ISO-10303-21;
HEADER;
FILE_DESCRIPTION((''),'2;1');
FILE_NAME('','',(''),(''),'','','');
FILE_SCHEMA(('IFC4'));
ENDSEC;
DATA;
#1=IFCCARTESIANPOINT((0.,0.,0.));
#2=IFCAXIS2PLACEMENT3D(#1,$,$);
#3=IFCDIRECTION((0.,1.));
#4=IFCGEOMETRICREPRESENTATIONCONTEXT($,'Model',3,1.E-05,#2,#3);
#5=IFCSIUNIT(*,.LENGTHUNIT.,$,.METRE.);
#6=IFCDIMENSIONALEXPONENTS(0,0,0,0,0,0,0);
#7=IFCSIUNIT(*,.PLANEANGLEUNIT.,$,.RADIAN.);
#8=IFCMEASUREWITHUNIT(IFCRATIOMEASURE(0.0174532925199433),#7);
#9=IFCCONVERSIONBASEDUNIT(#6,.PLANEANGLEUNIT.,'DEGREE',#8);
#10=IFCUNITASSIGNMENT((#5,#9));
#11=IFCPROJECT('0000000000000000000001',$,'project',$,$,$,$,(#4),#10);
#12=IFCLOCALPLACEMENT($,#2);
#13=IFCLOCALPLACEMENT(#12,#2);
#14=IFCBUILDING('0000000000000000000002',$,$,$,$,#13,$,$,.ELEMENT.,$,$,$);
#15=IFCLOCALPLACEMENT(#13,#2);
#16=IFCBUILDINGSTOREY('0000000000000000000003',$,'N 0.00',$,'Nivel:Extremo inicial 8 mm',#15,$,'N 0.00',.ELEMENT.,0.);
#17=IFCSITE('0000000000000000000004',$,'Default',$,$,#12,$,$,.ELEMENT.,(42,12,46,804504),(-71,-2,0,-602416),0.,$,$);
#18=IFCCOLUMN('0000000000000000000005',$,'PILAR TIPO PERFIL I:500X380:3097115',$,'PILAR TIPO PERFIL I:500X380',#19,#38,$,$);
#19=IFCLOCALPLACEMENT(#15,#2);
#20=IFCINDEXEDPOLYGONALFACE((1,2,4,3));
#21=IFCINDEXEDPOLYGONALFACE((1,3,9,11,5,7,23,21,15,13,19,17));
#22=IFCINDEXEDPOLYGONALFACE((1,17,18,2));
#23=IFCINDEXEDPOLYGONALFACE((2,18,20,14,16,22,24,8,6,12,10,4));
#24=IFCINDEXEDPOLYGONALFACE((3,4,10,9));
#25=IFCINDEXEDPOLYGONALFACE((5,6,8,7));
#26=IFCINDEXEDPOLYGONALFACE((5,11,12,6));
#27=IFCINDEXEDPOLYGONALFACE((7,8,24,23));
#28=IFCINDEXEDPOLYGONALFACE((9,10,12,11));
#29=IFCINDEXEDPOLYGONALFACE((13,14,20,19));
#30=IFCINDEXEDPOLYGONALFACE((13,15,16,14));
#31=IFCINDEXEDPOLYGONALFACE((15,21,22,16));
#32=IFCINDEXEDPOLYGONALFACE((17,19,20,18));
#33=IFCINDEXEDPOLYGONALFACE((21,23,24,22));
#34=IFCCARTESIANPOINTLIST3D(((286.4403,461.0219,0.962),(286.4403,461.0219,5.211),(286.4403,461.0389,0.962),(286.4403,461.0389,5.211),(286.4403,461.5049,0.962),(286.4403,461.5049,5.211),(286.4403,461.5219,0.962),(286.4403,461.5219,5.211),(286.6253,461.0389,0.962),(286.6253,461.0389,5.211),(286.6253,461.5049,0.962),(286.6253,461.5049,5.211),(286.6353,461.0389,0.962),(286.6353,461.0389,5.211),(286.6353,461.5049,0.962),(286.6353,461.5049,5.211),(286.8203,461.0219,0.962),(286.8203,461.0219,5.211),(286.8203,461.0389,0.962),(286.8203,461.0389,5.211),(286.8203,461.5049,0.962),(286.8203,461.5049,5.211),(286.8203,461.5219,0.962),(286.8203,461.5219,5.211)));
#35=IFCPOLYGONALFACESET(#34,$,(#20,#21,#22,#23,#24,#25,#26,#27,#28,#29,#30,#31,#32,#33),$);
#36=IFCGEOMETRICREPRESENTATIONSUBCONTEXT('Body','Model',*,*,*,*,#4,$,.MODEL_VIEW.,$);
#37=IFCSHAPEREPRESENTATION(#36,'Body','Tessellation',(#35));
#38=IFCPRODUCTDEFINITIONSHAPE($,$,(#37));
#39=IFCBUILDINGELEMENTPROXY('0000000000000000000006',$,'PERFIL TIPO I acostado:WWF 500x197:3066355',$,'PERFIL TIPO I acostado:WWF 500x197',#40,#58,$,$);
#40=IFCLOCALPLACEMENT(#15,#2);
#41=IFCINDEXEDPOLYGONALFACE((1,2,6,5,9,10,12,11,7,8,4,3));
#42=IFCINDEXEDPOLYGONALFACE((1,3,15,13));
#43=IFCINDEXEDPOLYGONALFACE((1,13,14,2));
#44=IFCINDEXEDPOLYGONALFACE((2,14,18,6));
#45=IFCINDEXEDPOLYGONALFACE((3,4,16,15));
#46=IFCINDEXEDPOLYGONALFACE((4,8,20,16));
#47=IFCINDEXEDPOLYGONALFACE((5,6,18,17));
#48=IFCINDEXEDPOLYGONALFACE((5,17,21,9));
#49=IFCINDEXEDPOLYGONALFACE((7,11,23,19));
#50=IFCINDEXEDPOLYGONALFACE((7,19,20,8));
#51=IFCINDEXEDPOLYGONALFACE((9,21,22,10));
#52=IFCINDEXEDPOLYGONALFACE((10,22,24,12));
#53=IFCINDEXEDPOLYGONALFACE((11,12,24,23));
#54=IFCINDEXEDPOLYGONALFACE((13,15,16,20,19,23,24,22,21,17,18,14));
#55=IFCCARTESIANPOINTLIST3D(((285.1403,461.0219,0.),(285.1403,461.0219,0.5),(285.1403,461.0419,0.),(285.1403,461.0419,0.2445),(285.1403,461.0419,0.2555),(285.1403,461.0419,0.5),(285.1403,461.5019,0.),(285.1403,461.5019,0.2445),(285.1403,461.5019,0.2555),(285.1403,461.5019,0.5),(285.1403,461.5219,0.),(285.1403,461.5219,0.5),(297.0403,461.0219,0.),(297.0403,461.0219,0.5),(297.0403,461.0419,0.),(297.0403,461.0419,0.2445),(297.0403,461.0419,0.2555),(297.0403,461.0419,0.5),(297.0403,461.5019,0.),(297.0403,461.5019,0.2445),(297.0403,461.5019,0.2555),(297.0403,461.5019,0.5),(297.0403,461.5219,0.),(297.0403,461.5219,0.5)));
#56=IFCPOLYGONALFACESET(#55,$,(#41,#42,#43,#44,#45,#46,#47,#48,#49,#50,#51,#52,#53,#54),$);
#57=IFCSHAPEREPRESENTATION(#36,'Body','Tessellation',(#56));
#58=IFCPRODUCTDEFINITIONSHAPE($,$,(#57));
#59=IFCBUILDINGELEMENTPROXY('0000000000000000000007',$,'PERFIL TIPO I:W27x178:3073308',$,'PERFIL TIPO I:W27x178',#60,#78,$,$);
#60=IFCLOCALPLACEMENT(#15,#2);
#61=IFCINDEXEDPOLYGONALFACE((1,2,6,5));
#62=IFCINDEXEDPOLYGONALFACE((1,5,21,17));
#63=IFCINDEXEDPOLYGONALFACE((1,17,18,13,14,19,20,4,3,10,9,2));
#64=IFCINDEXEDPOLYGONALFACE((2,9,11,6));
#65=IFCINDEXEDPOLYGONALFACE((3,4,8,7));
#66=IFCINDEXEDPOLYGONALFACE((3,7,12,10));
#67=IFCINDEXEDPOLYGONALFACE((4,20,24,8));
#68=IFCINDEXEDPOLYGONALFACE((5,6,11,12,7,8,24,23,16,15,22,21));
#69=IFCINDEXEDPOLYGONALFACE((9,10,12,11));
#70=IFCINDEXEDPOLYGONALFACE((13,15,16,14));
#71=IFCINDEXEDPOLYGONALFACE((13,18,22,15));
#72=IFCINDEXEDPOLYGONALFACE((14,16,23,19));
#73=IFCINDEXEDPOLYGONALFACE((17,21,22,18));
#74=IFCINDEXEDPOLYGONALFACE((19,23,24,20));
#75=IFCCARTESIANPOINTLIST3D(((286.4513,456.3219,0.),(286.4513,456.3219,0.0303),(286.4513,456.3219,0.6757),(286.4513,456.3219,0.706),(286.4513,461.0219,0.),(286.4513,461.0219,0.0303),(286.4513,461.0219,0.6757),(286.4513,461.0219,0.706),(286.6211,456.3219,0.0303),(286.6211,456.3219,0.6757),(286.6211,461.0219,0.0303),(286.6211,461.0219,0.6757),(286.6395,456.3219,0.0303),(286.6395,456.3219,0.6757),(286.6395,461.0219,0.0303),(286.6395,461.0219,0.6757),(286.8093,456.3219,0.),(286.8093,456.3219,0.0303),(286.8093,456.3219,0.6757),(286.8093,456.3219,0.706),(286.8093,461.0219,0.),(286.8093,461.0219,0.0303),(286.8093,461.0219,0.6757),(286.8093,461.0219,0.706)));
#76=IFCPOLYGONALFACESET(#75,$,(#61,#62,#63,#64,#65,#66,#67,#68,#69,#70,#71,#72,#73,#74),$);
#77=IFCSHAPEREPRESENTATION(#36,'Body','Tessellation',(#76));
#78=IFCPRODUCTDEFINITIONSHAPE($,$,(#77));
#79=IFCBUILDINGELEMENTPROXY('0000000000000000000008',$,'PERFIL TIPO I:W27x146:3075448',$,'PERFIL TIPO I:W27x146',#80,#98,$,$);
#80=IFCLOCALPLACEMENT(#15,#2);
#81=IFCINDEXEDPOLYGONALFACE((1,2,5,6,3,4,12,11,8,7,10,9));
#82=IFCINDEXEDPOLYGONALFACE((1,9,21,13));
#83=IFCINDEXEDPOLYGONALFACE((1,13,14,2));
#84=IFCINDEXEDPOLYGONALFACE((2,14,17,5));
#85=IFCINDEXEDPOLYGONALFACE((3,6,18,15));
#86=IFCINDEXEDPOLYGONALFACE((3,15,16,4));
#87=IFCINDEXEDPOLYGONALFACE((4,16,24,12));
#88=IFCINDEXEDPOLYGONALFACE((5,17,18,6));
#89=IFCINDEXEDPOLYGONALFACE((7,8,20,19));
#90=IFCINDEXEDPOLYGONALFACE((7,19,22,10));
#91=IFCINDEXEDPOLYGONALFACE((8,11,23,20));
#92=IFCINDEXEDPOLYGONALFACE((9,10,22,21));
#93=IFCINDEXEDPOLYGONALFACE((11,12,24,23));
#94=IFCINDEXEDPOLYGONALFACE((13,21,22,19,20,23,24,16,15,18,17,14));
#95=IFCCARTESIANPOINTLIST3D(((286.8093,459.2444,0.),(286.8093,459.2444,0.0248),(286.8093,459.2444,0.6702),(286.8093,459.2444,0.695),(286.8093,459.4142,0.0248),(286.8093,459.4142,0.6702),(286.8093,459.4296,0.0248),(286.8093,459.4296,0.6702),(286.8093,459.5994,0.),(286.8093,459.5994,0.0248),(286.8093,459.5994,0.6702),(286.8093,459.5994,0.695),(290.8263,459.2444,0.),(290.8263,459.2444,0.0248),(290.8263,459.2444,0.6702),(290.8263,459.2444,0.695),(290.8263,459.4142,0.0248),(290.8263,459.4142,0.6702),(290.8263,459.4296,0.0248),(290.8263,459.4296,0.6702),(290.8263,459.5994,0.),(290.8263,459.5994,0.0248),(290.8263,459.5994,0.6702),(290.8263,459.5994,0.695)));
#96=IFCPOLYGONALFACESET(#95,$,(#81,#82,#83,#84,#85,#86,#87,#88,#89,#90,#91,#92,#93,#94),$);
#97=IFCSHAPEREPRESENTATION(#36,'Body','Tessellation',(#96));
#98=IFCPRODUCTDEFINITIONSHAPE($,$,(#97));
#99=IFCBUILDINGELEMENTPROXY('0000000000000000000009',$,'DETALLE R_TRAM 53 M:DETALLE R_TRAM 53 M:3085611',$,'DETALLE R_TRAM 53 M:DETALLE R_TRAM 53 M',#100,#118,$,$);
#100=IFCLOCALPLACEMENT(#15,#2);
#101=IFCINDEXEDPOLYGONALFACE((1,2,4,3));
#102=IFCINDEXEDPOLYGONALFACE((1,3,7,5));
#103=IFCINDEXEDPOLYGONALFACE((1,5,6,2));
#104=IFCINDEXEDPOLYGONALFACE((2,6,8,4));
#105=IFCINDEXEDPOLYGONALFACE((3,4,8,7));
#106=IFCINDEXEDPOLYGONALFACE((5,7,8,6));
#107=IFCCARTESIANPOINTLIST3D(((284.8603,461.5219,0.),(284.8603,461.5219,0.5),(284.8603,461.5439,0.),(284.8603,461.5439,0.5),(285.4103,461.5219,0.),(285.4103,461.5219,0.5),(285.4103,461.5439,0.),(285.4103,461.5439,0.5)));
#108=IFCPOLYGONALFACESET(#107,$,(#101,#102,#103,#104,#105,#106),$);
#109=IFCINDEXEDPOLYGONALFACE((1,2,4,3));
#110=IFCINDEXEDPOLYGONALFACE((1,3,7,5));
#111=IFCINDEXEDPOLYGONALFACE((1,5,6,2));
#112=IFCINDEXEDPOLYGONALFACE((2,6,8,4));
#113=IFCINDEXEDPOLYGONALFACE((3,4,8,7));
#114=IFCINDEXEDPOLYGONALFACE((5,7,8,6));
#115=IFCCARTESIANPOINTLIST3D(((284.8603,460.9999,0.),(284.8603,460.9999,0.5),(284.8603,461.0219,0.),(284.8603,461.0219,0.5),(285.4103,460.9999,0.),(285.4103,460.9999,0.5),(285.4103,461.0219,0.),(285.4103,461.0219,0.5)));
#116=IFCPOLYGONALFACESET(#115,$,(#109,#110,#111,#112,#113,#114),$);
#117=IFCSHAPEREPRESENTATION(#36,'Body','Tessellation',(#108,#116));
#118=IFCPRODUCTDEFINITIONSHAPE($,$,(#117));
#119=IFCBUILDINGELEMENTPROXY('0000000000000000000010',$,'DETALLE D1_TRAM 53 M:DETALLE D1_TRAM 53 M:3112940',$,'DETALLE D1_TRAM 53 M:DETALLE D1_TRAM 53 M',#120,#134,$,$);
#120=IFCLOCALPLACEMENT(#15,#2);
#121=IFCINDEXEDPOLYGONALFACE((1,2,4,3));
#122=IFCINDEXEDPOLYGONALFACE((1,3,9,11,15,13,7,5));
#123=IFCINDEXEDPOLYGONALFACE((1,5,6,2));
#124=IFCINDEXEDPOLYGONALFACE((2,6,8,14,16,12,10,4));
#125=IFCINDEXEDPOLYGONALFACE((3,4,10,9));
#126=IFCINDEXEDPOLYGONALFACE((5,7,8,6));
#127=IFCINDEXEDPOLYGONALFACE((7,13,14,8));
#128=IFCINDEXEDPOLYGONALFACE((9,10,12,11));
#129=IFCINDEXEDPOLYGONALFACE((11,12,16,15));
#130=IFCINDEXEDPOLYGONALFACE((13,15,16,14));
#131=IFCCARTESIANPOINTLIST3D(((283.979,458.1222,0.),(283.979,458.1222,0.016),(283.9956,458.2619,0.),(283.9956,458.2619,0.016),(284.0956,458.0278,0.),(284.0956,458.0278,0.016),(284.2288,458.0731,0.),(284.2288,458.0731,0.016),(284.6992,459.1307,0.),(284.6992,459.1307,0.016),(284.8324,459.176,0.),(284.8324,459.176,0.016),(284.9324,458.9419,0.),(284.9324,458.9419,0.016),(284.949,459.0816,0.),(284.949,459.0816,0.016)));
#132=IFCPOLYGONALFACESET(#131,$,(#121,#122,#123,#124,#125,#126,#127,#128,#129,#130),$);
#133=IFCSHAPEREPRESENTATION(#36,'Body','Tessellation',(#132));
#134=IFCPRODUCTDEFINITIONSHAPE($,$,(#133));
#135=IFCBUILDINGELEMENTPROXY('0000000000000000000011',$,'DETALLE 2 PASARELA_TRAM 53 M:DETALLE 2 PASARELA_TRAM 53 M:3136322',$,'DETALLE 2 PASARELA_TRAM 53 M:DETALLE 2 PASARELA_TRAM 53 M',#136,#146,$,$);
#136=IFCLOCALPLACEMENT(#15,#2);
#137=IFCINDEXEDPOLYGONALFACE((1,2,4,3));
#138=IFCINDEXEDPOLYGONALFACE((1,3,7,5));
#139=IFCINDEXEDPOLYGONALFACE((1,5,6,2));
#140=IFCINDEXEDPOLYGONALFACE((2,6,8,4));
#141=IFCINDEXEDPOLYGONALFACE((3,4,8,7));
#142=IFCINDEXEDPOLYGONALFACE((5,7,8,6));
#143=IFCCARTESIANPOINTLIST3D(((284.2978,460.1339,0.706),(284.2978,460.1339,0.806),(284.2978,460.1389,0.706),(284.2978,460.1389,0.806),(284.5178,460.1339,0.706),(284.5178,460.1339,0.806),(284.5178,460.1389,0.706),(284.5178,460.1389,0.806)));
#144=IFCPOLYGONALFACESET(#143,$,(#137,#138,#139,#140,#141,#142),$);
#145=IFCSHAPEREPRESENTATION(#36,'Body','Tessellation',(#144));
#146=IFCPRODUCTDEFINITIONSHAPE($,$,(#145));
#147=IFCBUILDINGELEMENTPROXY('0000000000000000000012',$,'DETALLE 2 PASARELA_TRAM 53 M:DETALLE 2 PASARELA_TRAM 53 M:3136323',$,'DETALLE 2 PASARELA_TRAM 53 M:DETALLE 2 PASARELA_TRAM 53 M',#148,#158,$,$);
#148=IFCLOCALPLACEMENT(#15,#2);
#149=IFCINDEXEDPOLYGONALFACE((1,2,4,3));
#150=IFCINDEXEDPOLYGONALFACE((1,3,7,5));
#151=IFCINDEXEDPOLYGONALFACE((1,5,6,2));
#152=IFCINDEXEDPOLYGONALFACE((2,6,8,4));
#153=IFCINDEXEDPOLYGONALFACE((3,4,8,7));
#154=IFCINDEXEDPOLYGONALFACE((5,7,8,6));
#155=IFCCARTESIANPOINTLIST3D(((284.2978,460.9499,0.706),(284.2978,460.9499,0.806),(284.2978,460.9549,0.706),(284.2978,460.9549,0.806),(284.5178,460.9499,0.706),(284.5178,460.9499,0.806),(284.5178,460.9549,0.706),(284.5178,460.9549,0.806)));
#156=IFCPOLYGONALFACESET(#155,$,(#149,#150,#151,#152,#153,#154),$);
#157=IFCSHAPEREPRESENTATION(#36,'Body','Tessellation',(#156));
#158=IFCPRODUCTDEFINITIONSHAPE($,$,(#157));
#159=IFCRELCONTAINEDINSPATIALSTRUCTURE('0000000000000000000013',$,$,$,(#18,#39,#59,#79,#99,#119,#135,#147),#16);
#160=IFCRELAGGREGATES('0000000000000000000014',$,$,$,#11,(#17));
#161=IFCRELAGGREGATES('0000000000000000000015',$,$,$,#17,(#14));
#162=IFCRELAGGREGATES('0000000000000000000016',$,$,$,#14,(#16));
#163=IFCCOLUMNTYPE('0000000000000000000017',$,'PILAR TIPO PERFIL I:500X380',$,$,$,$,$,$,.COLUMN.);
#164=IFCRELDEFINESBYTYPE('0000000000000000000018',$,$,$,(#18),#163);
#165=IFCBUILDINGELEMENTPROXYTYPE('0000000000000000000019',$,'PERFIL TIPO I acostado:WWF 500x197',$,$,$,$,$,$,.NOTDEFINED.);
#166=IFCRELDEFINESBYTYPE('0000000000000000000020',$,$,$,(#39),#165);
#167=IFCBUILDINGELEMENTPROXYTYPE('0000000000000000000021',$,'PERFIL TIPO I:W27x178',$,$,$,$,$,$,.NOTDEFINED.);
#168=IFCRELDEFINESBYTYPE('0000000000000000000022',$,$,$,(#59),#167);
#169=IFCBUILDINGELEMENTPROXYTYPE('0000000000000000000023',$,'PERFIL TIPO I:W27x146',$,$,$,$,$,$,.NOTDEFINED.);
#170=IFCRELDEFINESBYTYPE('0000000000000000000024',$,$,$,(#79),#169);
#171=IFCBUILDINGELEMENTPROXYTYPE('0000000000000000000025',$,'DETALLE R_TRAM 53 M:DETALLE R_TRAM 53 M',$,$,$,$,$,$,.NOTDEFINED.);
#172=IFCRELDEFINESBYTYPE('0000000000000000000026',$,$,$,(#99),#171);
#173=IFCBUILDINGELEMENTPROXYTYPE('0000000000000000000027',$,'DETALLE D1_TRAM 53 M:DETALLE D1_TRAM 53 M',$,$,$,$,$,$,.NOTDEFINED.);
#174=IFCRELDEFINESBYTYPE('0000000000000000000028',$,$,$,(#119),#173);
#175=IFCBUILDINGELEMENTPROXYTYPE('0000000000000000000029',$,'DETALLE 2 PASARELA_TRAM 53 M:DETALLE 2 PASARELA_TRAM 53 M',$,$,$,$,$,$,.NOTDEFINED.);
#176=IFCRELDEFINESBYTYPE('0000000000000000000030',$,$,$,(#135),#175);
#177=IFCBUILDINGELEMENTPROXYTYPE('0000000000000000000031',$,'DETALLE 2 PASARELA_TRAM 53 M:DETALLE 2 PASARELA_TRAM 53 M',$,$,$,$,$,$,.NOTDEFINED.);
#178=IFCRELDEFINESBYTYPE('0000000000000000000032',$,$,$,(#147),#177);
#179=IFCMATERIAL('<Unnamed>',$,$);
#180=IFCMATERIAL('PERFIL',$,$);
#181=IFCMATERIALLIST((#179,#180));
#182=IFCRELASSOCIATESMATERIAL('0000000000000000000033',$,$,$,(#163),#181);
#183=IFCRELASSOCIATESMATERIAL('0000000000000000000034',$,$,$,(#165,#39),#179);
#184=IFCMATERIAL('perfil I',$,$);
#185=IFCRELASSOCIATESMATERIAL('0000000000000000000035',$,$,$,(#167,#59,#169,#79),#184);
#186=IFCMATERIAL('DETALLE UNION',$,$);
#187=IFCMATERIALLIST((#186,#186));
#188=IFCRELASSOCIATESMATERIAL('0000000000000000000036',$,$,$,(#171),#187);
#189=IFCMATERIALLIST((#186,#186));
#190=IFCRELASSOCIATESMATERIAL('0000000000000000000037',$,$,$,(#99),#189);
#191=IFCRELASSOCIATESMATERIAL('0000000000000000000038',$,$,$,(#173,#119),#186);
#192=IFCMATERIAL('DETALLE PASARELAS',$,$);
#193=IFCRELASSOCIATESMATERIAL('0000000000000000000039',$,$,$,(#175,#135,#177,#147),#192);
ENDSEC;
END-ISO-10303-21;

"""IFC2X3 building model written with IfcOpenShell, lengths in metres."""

from ifc_helpers import new_model, entity, si_unit, converted_unit, direction, frame, frame_2d, origin, place, context, subcontext, project, spatial, polyline, rectangle, i_section, outline, extrude, source, transform, mapped, material, material_list, type_object, type_shapes, element, save


model = new_model("IFC2X3")

# Units and contexts
model_context = context("Model", 3, precision=1e-05, world=origin(), true_north=direction((0.0, 1.0)))
body_context = subcontext(model_context, "Body", "Model", "MODEL_VIEW")
ifc_project = project(units=[si_unit("LENGTHUNIT", "METRE"), converted_unit("PLANEANGLEUNIT", "DEGREE", entity("IfcRatioMeasure", 0.0174532925199433), si_unit("PLANEANGLEUNIT", "RADIAN"), dimensions=[0, 0, 0, 0, 0, 0, 0])], contexts=[model_context])

# Site, building, storey
site_placement = place(None, origin())
site = spatial("IfcSite", under=ifc_project, at=site_placement, Name="Default", CompositionType="ELEMENT", RefLatitude=(42, 12, 46, 804504), RefLongitude=(-71, -2, 0, -602416), RefElevation=0.0)
building_placement = place(site_placement, origin())
building = spatial("IfcBuilding", under=site, at=building_placement, CompositionType="ELEMENT")
storey_placement = place(building_placement, origin())
storey = spatial("IfcBuildingStorey", under=building, at=storey_placement, Name="N 0.00", ObjectType="Nivel:Extremo inicial 8 mm", LongName="N 0.00", CompositionType="ELEMENT", Elevation=0.0)

# Column
ifc_material_1 = material(Name="<Unnamed>")
ifc_material_2 = material(Name="PERFIL")
ifc_material_list_1 = material_list([ifc_material_1, ifc_material_2])
column_type = type_object("IfcColumnType", Name="PILAR TIPO PERFIL I:500X380", PredefinedType="COLUMN", material=ifc_material_list_1)
shared_shape_1 = source(origin(), body_context, "Body", "SweptSolid", [
    extrude(i_section(OverallWidth=0.38, OverallDepth=0.5, WebThickness=0.01, FlangeThickness=0.017, at=frame_2d((0.0, 0.0), x_axis=(1.0, 0.0))), frame((0.0, 0.0, 0.962), z_axis=(0.0, 0.0, 1.0), x_axis=(0.0, -1.0, 0.0)), (0.0, 0.0, 1.0), 4.249),
])
type_shapes(column_type, [shared_shape_1])
column_placement = place(storey_placement, frame((286.6303, 461.2719, 0.0), z_axis=(0.0, 0.0, 1.0), x_axis=(0.0, -1.0, 0.0)))
element("IfcColumn", 1, at=column_placement, inside=storey, type_object=column_type, Name="PILAR TIPO PERFIL I:500X380:3097115", ObjectType="PILAR TIPO PERFIL I:500X380", context=body_context, shape_type="MappedRepresentation", body=[
    mapped(shared_shape_1, transform((0.0, 0.0, 0.0), scale=1.0)),
])

# Building element proxies
building_element_proxy_type_1 = type_object("IfcBuildingElementProxyType", Name="PERFIL TIPO I acostado:WWF 500x197", PredefinedType="NOTDEFINED", material=ifc_material_1)
shared_shape_2 = source(origin(), body_context, "Body", "SweptSolid", [
    extrude(outline(polyline([(-0.25, -0.23), (-0.25, -0.25), (0.25, -0.25), (0.25, -0.23), (0.0055, -0.23), (0.0055, 0.23), (0.25, 0.23), (0.25, 0.25), (-0.25, 0.25), (-0.25, 0.23), (-0.0055, 0.23), (-0.0055, -0.23), (-0.25, -0.23)])), frame((0.0, 0.0, 0.25), z_axis=(-1.0, 0.0, 0.0), x_axis=(0.0, 0.0, -1.0)), (0.0, 0.0, -1.0), 11.9),
])
type_shapes(building_element_proxy_type_1, [shared_shape_2])
proxy_1_placement = place(storey_placement, frame((285.1403, 461.2719, 0.0)))
element("IfcBuildingElementProxy", 2, at=proxy_1_placement, inside=storey, type_object=building_element_proxy_type_1, material=ifc_material_1, Name="PERFIL TIPO I acostado:WWF 500x197:3066355", ObjectType="PERFIL TIPO I acostado:WWF 500x197", context=body_context, shape_type="MappedRepresentation", body=[
    mapped(shared_shape_2, transform((0.0, 0.0, 0.0), scale=1.0)),
])
ifc_material_3 = material(Name="perfil I")
building_element_proxy_type_2 = type_object("IfcBuildingElementProxyType", Name="PERFIL TIPO I:W27x178", PredefinedType="NOTDEFINED", material=ifc_material_3)
shared_shape_3 = source(origin(), body_context, "Body", "SweptSolid", [
    extrude(outline(polyline([(0.3227, -0.179), (0.353, -0.179), (0.353, 0.179), (0.3227, 0.179), (0.3227, 0.0092), (-0.3227, 0.0092), (-0.3227, 0.179), (-0.353, 0.179), (-0.353, -0.179), (-0.3227, -0.179), (-0.3227, -0.0092), (0.3227, -0.0092), (0.3227, -0.179)])), frame((0.0, 0.0, 0.353), z_axis=(1.0, 0.0, 0.0), x_axis=(0.0, 0.0, 1.0)), (0.0, 0.0, 1.0), 4.7),
])
type_shapes(building_element_proxy_type_2, [shared_shape_3])
proxy_2_placement = place(storey_placement, frame((286.6303, 461.0219, 0.0), z_axis=(0.0, 0.0, 1.0), x_axis=(0.0, -1.0, 0.0)))
element("IfcBuildingElementProxy", 3, at=proxy_2_placement, inside=storey, type_object=building_element_proxy_type_2, material=ifc_material_3, Name="PERFIL TIPO I:W27x178:3073308", ObjectType="PERFIL TIPO I:W27x178", context=body_context, shape_type="MappedRepresentation", body=[
    mapped(shared_shape_3, transform((0.0, 0.0, 0.0), scale=1.0)),
])
building_element_proxy_type_3 = type_object("IfcBuildingElementProxyType", Name="PERFIL TIPO I:W27x146", PredefinedType="NOTDEFINED", material=ifc_material_3)
shared_shape_4 = source(origin(), body_context, "Body", "SweptSolid", [
    extrude(outline(polyline([(0.3227, -0.1775), (0.3475, -0.1775), (0.3475, 0.1775), (0.3227, 0.1775), (0.3227, 0.0077), (-0.3227, 0.0077), (-0.3227, 0.1775), (-0.3475, 0.1775), (-0.3475, -0.1775), (-0.3227, -0.1775), (-0.3227, -0.0077), (0.3227, -0.0077), (0.3227, -0.1775)])), frame((0.0, 0.0, 0.3475), z_axis=(1.0, 0.0, 0.0), x_axis=(0.0, 0.0, 1.0)), (0.0, 0.0, 1.0), 4.017),
])
type_shapes(building_element_proxy_type_3, [shared_shape_4])
proxy_3_placement = place(storey_placement, frame((286.8093, 459.4219, 0.0)))
element("IfcBuildingElementProxy", 4, at=proxy_3_placement, inside=storey, type_object=building_element_proxy_type_3, material=ifc_material_3, Name="PERFIL TIPO I:W27x146:3075448", ObjectType="PERFIL TIPO I:W27x146", context=body_context, shape_type="MappedRepresentation", body=[
    mapped(shared_shape_4, transform((0.0, 0.0, 0.0), scale=1.0)),
])
ifc_material_4 = material(Name="DETALLE UNION")
ifc_material_list_2 = material_list([ifc_material_4, ifc_material_4])
ifc_material_list_3 = material_list([ifc_material_4, ifc_material_4])
building_element_proxy_type_4 = type_object("IfcBuildingElementProxyType", Name="DETALLE R_TRAM 53 M:DETALLE R_TRAM 53 M", PredefinedType="NOTDEFINED", material=ifc_material_list_3)
shared_shape_5 = source(origin(), body_context, "Body", "SweptSolid", [
    extrude(rectangle(XDim=0.55, YDim=0.022, at=frame_2d((0.0, 0.0), x_axis=(1.0, 0.0))), frame((0.275, 0.011, 0.0), z_axis=(0.0, 0.0, 1.0), x_axis=(-1.0, 0.0, 0.0)), (0.0, 0.0, 1.0), 0.5),
    extrude(rectangle(XDim=0.55, YDim=0.022, at=frame_2d((0.0, 0.0), x_axis=(1.0, 0.0))), frame((0.275, -0.511, 0.0), z_axis=(0.0, 0.0, 1.0), x_axis=(-1.0, 0.0, 0.0)), (0.0, 0.0, 1.0), 0.5),
])
type_shapes(building_element_proxy_type_4, [shared_shape_5])
proxy_4_placement = place(storey_placement, frame((284.8603, 461.5219, 0.0)))
element("IfcBuildingElementProxy", 5, at=proxy_4_placement, inside=storey, type_object=building_element_proxy_type_4, material=ifc_material_list_2, Name="DETALLE R_TRAM 53 M:DETALLE R_TRAM 53 M:3085611", ObjectType="DETALLE R_TRAM 53 M:DETALLE R_TRAM 53 M", context=body_context, shape_type="MappedRepresentation", body=[
    mapped(shared_shape_5, transform((0.0, 0.0, 0.0), scale=1.0)),
])
building_element_proxy_type_5 = type_object("IfcBuildingElementProxyType", Name="DETALLE D1_TRAM 53 M:DETALLE D1_TRAM 53 M", PredefinedType="NOTDEFINED", material=ifc_material_4)
shared_shape_6 = source(origin(), body_context, "Body", "SweptSolid", [
    extrude(outline(polyline([(-0.075, -0.678), (0.075, -0.678), (0.15, -0.559), (0.15, 0.559), (0.075, 0.678), (-0.075, 0.678), (-0.15, 0.559), (-0.15, -0.559), (-0.075, -0.678)])), frame((0.0, 0.0, 0.0), z_axis=(0.0, 0.0, 1.0), x_axis=(-0.777146, 0.62932, 0.0)), (0.0, 0.0, 1.0), 0.016),
])
type_shapes(building_element_proxy_type_5, [shared_shape_6])
proxy_5_placement = place(storey_placement, frame((284.464, 458.6019, 0.0)))
element("IfcBuildingElementProxy", 6, at=proxy_5_placement, inside=storey, type_object=building_element_proxy_type_5, material=ifc_material_4, Name="DETALLE D1_TRAM 53 M:DETALLE D1_TRAM 53 M:3112940", ObjectType="DETALLE D1_TRAM 53 M:DETALLE D1_TRAM 53 M", context=body_context, shape_type="MappedRepresentation", body=[
    mapped(shared_shape_6, transform((0.0, 0.0, 0.0), scale=1.0)),
])
ifc_material_5 = material(Name="DETALLE PASARELAS")
building_element_proxy_type_6 = type_object("IfcBuildingElementProxyType", Name="DETALLE 2 PASARELA_TRAM 53 M:DETALLE 2 PASARELA_TRAM 53 M", PredefinedType="NOTDEFINED", material=ifc_material_5)
shared_shape_7 = source(origin(), body_context, "Body", "SweptSolid", [
    extrude(rectangle(XDim=0.22, YDim=0.005, at=frame_2d((0.0, 0.0), x_axis=(1.0, 0.0))), frame((0.11, 0.0475, 0.0), z_axis=(0.0, 0.0, 1.0), x_axis=(-1.0, 0.0, 0.0)), (0.0, 0.0, 1.0), 0.1),
])
type_shapes(building_element_proxy_type_6, [shared_shape_7])
proxy_6_placement = place(storey_placement, frame((284.2978, 460.0889, 0.706)))
element("IfcBuildingElementProxy", 7, at=proxy_6_placement, inside=storey, type_object=building_element_proxy_type_6, material=ifc_material_5, Name="DETALLE 2 PASARELA_TRAM 53 M:DETALLE 2 PASARELA_TRAM 53 M:3136322", ObjectType="DETALLE 2 PASARELA_TRAM 53 M:DETALLE 2 PASARELA_TRAM 53 M", context=body_context, shape_type="MappedRepresentation", body=[
    mapped(shared_shape_7, transform((0.0, 0.0, 0.0), scale=1.0)),
])
building_element_proxy_type_7 = type_object("IfcBuildingElementProxyType", Name="DETALLE 2 PASARELA_TRAM 53 M:DETALLE 2 PASARELA_TRAM 53 M", PredefinedType="NOTDEFINED", material=ifc_material_5)
shared_shape_8 = source(origin(), body_context, "Body", "SweptSolid", [
    extrude(rectangle(XDim=0.005, YDim=0.22, at=frame_2d((0.0, 0.0), x_axis=(1.0, 0.0))), frame((0.11, -0.0475, 0.0), z_axis=(0.0, 0.0, 1.0), x_axis=(0.0, 1.0, 0.0)), (0.0, 0.0, 1.0), 0.1),
])
type_shapes(building_element_proxy_type_7, [shared_shape_8])
proxy_7_placement = place(storey_placement, frame((284.2978, 460.9999, 0.706)))
element("IfcBuildingElementProxy", 8, at=proxy_7_placement, inside=storey, type_object=building_element_proxy_type_7, material=ifc_material_5, Name="DETALLE 2 PASARELA_TRAM 53 M:DETALLE 2 PASARELA_TRAM 53 M:3136323", ObjectType="DETALLE 2 PASARELA_TRAM 53 M:DETALLE 2 PASARELA_TRAM 53 M", context=body_context, shape_type="MappedRepresentation", body=[
    mapped(shared_shape_8, transform((0.0, 0.0, 0.0), scale=1.0)),
])

save(model, "model.ifc")
